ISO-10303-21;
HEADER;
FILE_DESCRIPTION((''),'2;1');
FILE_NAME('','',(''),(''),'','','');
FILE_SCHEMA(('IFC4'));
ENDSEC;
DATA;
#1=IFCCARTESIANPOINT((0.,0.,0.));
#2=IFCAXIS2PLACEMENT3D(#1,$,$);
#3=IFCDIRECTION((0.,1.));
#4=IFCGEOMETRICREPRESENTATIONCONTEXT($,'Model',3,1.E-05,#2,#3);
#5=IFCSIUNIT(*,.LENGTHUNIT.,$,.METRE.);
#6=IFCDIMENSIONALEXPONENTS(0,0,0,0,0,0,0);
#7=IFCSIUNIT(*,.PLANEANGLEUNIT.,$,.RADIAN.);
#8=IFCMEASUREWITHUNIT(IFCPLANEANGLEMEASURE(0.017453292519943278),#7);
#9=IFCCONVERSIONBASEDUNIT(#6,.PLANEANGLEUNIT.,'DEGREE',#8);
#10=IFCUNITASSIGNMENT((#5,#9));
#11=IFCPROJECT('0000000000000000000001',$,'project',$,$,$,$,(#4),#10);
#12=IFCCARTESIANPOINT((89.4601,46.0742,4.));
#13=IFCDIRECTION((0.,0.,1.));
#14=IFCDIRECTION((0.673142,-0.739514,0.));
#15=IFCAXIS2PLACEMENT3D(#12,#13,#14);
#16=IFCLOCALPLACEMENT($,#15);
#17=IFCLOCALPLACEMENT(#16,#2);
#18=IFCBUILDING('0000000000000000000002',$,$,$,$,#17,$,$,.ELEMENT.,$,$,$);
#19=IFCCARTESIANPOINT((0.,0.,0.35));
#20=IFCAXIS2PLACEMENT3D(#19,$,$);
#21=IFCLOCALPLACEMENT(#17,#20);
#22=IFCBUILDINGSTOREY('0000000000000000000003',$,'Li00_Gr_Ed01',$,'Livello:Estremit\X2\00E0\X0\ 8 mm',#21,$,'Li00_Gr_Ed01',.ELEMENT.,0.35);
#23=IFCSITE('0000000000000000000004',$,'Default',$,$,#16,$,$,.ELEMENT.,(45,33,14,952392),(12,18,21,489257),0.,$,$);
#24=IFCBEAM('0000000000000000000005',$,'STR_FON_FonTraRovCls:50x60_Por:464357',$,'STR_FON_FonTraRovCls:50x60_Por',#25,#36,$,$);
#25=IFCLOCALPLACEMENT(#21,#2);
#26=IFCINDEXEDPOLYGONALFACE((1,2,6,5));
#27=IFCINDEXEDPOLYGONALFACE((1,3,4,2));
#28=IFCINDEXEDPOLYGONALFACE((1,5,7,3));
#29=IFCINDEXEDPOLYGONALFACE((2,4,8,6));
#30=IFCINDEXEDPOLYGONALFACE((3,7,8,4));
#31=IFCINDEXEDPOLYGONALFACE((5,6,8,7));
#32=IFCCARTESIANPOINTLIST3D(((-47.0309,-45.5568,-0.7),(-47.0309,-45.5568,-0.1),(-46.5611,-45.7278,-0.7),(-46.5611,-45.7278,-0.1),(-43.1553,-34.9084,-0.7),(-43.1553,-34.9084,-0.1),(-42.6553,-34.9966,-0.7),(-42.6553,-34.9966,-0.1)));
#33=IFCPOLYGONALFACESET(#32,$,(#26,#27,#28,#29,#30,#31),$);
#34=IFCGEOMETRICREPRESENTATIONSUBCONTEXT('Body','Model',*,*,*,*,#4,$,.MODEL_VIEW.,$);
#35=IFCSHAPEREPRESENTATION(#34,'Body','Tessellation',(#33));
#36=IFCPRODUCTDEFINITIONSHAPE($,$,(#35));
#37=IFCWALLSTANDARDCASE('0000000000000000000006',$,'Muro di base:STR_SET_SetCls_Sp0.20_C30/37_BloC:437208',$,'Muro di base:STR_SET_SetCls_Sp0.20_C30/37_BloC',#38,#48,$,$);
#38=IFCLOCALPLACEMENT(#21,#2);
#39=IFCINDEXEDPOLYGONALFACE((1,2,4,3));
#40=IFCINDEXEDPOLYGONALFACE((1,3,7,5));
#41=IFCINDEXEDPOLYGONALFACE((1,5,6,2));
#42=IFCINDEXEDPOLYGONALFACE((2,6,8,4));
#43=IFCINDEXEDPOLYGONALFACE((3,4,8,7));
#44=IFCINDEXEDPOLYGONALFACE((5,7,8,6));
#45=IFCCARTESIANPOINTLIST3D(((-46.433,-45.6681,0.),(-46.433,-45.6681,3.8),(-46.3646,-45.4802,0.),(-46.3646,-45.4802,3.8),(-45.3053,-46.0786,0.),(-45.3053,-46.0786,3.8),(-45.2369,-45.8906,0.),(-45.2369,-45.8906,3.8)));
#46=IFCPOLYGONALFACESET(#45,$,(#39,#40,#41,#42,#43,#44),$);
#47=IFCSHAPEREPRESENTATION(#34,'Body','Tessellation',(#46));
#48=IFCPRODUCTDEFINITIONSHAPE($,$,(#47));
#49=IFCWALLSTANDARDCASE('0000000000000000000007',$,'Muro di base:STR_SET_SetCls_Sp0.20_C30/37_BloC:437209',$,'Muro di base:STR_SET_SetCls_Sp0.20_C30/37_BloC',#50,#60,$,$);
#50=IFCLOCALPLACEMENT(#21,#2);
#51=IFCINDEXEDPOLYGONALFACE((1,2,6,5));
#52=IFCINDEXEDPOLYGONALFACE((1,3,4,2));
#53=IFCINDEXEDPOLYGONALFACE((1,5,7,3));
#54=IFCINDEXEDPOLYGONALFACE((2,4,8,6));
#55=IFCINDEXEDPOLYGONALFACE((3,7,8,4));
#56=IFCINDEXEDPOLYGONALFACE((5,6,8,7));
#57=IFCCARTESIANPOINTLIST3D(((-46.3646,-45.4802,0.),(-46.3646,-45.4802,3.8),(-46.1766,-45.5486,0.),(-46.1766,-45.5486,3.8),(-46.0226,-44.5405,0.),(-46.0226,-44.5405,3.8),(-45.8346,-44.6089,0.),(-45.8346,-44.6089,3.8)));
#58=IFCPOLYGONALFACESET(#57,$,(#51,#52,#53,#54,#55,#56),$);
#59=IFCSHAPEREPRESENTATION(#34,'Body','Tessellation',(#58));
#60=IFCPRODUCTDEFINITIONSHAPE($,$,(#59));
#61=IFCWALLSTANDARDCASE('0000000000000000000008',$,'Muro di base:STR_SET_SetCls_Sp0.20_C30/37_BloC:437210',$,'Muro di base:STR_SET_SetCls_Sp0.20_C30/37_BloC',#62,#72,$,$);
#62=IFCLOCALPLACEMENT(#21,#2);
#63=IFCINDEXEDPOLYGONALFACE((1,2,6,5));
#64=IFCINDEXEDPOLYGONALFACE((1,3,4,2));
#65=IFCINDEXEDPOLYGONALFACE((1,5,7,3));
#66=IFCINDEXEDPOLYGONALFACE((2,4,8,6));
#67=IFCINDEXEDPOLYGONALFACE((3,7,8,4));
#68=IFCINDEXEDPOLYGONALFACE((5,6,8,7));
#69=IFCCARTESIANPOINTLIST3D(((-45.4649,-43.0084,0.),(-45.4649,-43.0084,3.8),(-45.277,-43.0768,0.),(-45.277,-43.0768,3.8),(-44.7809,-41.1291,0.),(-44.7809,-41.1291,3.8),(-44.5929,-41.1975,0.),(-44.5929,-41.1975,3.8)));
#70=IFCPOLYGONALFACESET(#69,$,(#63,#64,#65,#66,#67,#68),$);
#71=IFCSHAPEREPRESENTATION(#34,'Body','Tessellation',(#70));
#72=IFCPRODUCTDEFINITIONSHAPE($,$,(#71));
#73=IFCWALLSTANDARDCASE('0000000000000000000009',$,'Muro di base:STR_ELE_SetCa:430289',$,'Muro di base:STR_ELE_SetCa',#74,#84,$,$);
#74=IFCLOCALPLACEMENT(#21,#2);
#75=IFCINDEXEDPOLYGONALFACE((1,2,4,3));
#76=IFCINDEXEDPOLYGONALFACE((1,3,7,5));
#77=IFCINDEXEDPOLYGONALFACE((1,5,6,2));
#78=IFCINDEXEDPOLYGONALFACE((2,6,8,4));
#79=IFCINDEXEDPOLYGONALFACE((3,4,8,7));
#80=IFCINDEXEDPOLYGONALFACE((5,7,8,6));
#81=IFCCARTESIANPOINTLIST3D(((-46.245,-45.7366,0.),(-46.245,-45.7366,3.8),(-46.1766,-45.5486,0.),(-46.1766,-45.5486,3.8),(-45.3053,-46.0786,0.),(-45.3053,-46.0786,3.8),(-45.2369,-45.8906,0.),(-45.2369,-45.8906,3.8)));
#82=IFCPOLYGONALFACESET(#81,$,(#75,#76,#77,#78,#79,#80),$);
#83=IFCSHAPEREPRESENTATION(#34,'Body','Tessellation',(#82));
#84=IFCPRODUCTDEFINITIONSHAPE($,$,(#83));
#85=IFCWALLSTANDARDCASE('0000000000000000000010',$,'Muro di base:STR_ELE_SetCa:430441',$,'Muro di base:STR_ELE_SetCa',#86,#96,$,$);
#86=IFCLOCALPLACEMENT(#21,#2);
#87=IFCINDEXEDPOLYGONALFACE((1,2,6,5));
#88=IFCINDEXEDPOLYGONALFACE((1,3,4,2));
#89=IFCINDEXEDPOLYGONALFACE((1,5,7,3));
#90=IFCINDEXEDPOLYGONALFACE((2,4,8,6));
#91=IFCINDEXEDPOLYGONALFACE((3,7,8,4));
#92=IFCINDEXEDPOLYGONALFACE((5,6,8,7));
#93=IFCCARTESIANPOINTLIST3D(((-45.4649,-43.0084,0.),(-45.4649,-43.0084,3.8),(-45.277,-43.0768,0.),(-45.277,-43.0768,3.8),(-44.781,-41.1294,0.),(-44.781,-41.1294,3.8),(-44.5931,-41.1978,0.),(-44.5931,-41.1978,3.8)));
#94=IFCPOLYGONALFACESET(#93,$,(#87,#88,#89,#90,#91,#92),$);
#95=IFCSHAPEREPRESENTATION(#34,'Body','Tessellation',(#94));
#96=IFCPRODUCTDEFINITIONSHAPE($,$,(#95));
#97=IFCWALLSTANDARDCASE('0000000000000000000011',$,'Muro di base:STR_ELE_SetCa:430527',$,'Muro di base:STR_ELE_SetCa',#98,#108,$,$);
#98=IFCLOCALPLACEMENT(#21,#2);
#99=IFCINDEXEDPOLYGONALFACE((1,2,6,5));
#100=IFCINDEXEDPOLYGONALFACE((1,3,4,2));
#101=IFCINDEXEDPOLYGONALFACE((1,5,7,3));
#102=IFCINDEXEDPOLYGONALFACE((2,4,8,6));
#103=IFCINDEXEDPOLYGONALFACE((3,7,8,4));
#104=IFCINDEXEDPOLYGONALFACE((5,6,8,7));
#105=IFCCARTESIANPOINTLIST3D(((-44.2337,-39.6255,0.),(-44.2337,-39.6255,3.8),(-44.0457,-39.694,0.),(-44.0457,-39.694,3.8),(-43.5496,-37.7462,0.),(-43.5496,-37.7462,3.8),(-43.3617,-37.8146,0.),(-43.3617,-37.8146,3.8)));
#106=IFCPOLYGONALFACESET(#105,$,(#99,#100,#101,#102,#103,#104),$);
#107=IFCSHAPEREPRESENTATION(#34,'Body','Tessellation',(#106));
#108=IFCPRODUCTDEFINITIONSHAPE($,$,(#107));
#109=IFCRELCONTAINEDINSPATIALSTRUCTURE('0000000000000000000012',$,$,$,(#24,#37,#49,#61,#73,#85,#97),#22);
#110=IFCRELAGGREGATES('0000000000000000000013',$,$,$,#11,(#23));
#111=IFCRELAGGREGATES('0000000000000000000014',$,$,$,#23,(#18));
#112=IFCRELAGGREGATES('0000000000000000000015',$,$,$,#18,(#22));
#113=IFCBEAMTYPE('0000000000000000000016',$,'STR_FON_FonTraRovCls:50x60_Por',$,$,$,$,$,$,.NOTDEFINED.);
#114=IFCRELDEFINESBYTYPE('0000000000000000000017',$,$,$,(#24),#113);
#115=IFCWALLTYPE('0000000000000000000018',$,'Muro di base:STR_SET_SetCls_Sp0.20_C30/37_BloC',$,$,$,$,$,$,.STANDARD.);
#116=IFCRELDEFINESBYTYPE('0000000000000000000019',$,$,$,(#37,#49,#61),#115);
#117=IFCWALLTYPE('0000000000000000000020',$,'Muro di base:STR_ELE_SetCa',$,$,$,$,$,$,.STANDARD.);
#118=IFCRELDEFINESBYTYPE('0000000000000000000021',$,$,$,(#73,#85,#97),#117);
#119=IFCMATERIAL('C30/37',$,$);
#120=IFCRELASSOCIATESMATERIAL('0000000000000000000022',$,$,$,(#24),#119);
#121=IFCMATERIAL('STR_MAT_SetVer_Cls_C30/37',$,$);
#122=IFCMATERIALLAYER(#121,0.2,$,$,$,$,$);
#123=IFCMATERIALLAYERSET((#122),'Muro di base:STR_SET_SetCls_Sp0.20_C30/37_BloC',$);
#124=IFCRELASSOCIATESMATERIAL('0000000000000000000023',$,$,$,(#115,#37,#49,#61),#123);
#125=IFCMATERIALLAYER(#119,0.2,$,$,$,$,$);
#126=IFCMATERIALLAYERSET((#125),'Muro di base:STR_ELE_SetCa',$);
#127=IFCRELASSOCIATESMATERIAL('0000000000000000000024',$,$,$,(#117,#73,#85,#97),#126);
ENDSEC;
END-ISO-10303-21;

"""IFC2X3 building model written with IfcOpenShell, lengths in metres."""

from ifc_helpers import new_model, entity, si_unit, converted_unit, direction, frame, frame_2d, origin, place, context, subcontext, project, spatial, rectangle, extrude, clip, halfspace, material, layer, layer_set, layer_usage, type_object, element, save


model = new_model("IFC2X3")

# Units and contexts
model_context = context("Model", 3, precision=1e-05, world=origin(), true_north=direction((0.0, 1.0)))
body_context = subcontext(model_context, "Body", "Model", "MODEL_VIEW")
ifc_project = project(units=[si_unit("LENGTHUNIT", "METRE"), converted_unit("PLANEANGLEUNIT", "DEGREE", entity("IfcPlaneAngleMeasure", 0.017453292519943278), si_unit("PLANEANGLEUNIT", "RADIAN"), dimensions=[0, 0, 0, 0, 0, 0, 0])], contexts=[model_context])

# Site, building, storey
site_placement = place(None, frame((89.4601, 46.0742, 4.0), z_axis=(0.0, 0.0, 1.0), x_axis=(0.673142, -0.739514, 0.0)))
site = spatial("IfcSite", under=ifc_project, at=site_placement, Name="Default", CompositionType="ELEMENT", RefLatitude=(45, 33, 14, 952392), RefLongitude=(12, 18, 21, 489257), RefElevation=0.0)
building_placement = place(site_placement, origin())
building = spatial("IfcBuilding", under=site, at=building_placement, CompositionType="ELEMENT")
storey_placement = place(building_placement, frame((0.0, 0.0, 0.35)))
storey = spatial("IfcBuildingStorey", under=building, at=storey_placement, Name="Li00_Gr_Ed01", ObjectType="Livello:Estremità 8 mm", LongName="Li00_Gr_Ed01", CompositionType="ELEMENT", Elevation=0.35)

# Beam
ifc_material_1 = material(Name="C30/37")
beam_type_1 = type_object("IfcBeamType", Name="STR_FON_FonTraRovCls:50x60_Por", PredefinedType="NOTDEFINED")
beam_1_placement = place(storey_placement, frame((-46.7917, -45.6305, -0.1), z_axis=(0.0, 0.0, 1.0), x_axis=(0.34202, 0.939693, 0.0)))
element("IfcBeam", 1, at=beam_1_placement, inside=storey, type_object=beam_type_1, material=ifc_material_1, Name="STR_FON_FonTraRovCls:50x60_Por:464357", ObjectType="STR_FON_FonTraRovCls:50x60_Por", context=body_context, shape_type="SweptSolid", body=[
    clip(extrude(rectangle(XDim=0.6, YDim=0.5, at=frame_2d((0.0, 0.0), x_axis=(1.0, 0.0))), frame((-0.0126, 0.0, -0.3), z_axis=(1.0, 0.0, 0.0), x_axis=(0.0, 0.0, -1.0)), (0.0, 0.0, 1.0), 11.4199), halfspace(frame((11.3192, 0.25, 0.0), z_axis=(0.984808, 0.173648, 0.0), x_axis=(0.173648, -0.984808, 0.0)), False)),
])

# Walls
ifc_material_2 = material(Name="STR_MAT_SetVer_Cls_C30/37")
ifc_layer_1 = layer(ifc_material_2, 0.2)
ifc_layer_set_1 = layer_set([ifc_layer_1], Name="Muro di base:STR_SET_SetCls_Sp0.20_C30/37_BloC")
ifc_layer_usage_1 = layer_usage(ifc_layer_set_1, "AXIS2", "NEGATIVE", 0.1)
wall_type_1 = type_object("IfcWallType", Name="Muro di base:STR_SET_SetCls_Sp0.20_C30/37_BloC", PredefinedType="STANDARD", material=ifc_layer_set_1)
wall_1_placement = place(storey_placement, frame((-45.2711, -45.9846, 0.0), z_axis=(0.0, 0.0, 1.0), x_axis=(-0.939693, 0.34202, 0.0)))
element("IfcWallStandardCase", 2, at=wall_1_placement, inside=storey, type_object=wall_type_1, material=ifc_layer_usage_1, Name="Muro di base:STR_SET_SetCls_Sp0.20_C30/37_BloC:437208", ObjectType="Muro di base:STR_SET_SetCls_Sp0.20_C30/37_BloC", context=body_context, shape_type="SweptSolid", body=[
    extrude(rectangle(XDim=1.2, YDim=0.2, at=frame_2d((0.6, 0.0), x_axis=(-1.0, 0.0))), origin(), (0.0, 0.0, 1.0), 3.8),
])
wall_2_placement = place(storey_placement, frame((-45.9286, -44.5747, 0.0), z_axis=(0.0, 0.0, 1.0), x_axis=(-0.34202, -0.939693, 0.0)))
element("IfcWallStandardCase", 3, at=wall_2_placement, inside=storey, type_object=wall_type_1, material=ifc_layer_usage_1, Name="Muro di base:STR_SET_SetCls_Sp0.20_C30/37_BloC:437209", ObjectType="Muro di base:STR_SET_SetCls_Sp0.20_C30/37_BloC", context=body_context, shape_type="SweptSolid", body=[
    extrude(rectangle(XDim=1.0, YDim=0.2, at=frame_2d((0.5, 0.0), x_axis=(-1.0, 0.0))), origin(), (0.0, 0.0, 1.0), 3.8),
])
wall_3_placement = place(storey_placement, frame((-45.371, -43.0426, 0.0), z_axis=(0.0, 0.0, 1.0), x_axis=(0.34202, 0.939693, 0.0)))
element("IfcWallStandardCase", 4, at=wall_3_placement, inside=storey, type_object=wall_type_1, material=ifc_layer_usage_1, Name="Muro di base:STR_SET_SetCls_Sp0.20_C30/37_BloC:437210", ObjectType="Muro di base:STR_SET_SetCls_Sp0.20_C30/37_BloC", context=body_context, shape_type="SweptSolid", body=[
    extrude(rectangle(XDim=2.0, YDim=0.2, at=frame_2d((1.0, 0.0), x_axis=(-1.0, 0.0))), origin(), (0.0, 0.0, 1.0), 3.8),
])
ifc_layer_2 = layer(ifc_material_1, 0.2)
ifc_layer_set_2 = layer_set([ifc_layer_2], Name="Muro di base:STR_ELE_SetCa")
ifc_layer_usage_2 = layer_usage(ifc_layer_set_2, "AXIS2", "NEGATIVE", 0.1)
wall_type_2 = type_object("IfcWallType", Name="Muro di base:STR_ELE_SetCa", PredefinedType="STANDARD", material=ifc_layer_set_2)
wall_4_placement = place(storey_placement, frame((-45.2711, -45.9846, 0.0), z_axis=(0.0, 0.0, 1.0), x_axis=(-0.939697, 0.342009, 0.0)))
element("IfcWallStandardCase", 5, at=wall_4_placement, inside=storey, type_object=wall_type_2, material=ifc_layer_usage_2, Name="Muro di base:STR_ELE_SetCa:430289", ObjectType="Muro di base:STR_ELE_SetCa", context=body_context, shape_type="SweptSolid", body=[
    extrude(rectangle(XDim=1.0, YDim=0.2, at=frame_2d((0.5, 0.0), x_axis=(-1.0, 0.0))), origin(), (0.0, 0.0, 1.0), 3.8),
])
wall_5_placement = place(storey_placement, frame((-45.371, -43.0426, 0.0), z_axis=(0.0, 0.0, 1.0), x_axis=(0.34202, 0.939693, 0.0)))
element("IfcWallStandardCase", 6, at=wall_5_placement, inside=storey, type_object=wall_type_2, material=ifc_layer_usage_2, Name="Muro di base:STR_ELE_SetCa:430441", ObjectType="Muro di base:STR_ELE_SetCa", context=body_context, shape_type="SweptSolid", body=[
    extrude(rectangle(XDim=1.9996, YDim=0.2, at=frame_2d((0.9998, 0.0), x_axis=(-1.0, 0.0))), origin(), (0.0, 0.0, 1.0), 3.8),
])
wall_6_placement = place(storey_placement, frame((-44.1397, -39.6597, 0.0), z_axis=(0.0, 0.0, 1.0), x_axis=(0.34202, 0.939693, 0.0)))
element("IfcWallStandardCase", 7, at=wall_6_placement, inside=storey, type_object=wall_type_2, material=ifc_layer_usage_2, Name="Muro di base:STR_ELE_SetCa:430527", ObjectType="Muro di base:STR_ELE_SetCa", context=body_context, shape_type="SweptSolid", body=[
    extrude(rectangle(XDim=2.0, YDim=0.2, at=frame_2d((1.0, 0.0), x_axis=(-1.0, 0.0))), origin(), (0.0, 0.0, 1.0), 3.8),
])

save(model, "model.ifc")
